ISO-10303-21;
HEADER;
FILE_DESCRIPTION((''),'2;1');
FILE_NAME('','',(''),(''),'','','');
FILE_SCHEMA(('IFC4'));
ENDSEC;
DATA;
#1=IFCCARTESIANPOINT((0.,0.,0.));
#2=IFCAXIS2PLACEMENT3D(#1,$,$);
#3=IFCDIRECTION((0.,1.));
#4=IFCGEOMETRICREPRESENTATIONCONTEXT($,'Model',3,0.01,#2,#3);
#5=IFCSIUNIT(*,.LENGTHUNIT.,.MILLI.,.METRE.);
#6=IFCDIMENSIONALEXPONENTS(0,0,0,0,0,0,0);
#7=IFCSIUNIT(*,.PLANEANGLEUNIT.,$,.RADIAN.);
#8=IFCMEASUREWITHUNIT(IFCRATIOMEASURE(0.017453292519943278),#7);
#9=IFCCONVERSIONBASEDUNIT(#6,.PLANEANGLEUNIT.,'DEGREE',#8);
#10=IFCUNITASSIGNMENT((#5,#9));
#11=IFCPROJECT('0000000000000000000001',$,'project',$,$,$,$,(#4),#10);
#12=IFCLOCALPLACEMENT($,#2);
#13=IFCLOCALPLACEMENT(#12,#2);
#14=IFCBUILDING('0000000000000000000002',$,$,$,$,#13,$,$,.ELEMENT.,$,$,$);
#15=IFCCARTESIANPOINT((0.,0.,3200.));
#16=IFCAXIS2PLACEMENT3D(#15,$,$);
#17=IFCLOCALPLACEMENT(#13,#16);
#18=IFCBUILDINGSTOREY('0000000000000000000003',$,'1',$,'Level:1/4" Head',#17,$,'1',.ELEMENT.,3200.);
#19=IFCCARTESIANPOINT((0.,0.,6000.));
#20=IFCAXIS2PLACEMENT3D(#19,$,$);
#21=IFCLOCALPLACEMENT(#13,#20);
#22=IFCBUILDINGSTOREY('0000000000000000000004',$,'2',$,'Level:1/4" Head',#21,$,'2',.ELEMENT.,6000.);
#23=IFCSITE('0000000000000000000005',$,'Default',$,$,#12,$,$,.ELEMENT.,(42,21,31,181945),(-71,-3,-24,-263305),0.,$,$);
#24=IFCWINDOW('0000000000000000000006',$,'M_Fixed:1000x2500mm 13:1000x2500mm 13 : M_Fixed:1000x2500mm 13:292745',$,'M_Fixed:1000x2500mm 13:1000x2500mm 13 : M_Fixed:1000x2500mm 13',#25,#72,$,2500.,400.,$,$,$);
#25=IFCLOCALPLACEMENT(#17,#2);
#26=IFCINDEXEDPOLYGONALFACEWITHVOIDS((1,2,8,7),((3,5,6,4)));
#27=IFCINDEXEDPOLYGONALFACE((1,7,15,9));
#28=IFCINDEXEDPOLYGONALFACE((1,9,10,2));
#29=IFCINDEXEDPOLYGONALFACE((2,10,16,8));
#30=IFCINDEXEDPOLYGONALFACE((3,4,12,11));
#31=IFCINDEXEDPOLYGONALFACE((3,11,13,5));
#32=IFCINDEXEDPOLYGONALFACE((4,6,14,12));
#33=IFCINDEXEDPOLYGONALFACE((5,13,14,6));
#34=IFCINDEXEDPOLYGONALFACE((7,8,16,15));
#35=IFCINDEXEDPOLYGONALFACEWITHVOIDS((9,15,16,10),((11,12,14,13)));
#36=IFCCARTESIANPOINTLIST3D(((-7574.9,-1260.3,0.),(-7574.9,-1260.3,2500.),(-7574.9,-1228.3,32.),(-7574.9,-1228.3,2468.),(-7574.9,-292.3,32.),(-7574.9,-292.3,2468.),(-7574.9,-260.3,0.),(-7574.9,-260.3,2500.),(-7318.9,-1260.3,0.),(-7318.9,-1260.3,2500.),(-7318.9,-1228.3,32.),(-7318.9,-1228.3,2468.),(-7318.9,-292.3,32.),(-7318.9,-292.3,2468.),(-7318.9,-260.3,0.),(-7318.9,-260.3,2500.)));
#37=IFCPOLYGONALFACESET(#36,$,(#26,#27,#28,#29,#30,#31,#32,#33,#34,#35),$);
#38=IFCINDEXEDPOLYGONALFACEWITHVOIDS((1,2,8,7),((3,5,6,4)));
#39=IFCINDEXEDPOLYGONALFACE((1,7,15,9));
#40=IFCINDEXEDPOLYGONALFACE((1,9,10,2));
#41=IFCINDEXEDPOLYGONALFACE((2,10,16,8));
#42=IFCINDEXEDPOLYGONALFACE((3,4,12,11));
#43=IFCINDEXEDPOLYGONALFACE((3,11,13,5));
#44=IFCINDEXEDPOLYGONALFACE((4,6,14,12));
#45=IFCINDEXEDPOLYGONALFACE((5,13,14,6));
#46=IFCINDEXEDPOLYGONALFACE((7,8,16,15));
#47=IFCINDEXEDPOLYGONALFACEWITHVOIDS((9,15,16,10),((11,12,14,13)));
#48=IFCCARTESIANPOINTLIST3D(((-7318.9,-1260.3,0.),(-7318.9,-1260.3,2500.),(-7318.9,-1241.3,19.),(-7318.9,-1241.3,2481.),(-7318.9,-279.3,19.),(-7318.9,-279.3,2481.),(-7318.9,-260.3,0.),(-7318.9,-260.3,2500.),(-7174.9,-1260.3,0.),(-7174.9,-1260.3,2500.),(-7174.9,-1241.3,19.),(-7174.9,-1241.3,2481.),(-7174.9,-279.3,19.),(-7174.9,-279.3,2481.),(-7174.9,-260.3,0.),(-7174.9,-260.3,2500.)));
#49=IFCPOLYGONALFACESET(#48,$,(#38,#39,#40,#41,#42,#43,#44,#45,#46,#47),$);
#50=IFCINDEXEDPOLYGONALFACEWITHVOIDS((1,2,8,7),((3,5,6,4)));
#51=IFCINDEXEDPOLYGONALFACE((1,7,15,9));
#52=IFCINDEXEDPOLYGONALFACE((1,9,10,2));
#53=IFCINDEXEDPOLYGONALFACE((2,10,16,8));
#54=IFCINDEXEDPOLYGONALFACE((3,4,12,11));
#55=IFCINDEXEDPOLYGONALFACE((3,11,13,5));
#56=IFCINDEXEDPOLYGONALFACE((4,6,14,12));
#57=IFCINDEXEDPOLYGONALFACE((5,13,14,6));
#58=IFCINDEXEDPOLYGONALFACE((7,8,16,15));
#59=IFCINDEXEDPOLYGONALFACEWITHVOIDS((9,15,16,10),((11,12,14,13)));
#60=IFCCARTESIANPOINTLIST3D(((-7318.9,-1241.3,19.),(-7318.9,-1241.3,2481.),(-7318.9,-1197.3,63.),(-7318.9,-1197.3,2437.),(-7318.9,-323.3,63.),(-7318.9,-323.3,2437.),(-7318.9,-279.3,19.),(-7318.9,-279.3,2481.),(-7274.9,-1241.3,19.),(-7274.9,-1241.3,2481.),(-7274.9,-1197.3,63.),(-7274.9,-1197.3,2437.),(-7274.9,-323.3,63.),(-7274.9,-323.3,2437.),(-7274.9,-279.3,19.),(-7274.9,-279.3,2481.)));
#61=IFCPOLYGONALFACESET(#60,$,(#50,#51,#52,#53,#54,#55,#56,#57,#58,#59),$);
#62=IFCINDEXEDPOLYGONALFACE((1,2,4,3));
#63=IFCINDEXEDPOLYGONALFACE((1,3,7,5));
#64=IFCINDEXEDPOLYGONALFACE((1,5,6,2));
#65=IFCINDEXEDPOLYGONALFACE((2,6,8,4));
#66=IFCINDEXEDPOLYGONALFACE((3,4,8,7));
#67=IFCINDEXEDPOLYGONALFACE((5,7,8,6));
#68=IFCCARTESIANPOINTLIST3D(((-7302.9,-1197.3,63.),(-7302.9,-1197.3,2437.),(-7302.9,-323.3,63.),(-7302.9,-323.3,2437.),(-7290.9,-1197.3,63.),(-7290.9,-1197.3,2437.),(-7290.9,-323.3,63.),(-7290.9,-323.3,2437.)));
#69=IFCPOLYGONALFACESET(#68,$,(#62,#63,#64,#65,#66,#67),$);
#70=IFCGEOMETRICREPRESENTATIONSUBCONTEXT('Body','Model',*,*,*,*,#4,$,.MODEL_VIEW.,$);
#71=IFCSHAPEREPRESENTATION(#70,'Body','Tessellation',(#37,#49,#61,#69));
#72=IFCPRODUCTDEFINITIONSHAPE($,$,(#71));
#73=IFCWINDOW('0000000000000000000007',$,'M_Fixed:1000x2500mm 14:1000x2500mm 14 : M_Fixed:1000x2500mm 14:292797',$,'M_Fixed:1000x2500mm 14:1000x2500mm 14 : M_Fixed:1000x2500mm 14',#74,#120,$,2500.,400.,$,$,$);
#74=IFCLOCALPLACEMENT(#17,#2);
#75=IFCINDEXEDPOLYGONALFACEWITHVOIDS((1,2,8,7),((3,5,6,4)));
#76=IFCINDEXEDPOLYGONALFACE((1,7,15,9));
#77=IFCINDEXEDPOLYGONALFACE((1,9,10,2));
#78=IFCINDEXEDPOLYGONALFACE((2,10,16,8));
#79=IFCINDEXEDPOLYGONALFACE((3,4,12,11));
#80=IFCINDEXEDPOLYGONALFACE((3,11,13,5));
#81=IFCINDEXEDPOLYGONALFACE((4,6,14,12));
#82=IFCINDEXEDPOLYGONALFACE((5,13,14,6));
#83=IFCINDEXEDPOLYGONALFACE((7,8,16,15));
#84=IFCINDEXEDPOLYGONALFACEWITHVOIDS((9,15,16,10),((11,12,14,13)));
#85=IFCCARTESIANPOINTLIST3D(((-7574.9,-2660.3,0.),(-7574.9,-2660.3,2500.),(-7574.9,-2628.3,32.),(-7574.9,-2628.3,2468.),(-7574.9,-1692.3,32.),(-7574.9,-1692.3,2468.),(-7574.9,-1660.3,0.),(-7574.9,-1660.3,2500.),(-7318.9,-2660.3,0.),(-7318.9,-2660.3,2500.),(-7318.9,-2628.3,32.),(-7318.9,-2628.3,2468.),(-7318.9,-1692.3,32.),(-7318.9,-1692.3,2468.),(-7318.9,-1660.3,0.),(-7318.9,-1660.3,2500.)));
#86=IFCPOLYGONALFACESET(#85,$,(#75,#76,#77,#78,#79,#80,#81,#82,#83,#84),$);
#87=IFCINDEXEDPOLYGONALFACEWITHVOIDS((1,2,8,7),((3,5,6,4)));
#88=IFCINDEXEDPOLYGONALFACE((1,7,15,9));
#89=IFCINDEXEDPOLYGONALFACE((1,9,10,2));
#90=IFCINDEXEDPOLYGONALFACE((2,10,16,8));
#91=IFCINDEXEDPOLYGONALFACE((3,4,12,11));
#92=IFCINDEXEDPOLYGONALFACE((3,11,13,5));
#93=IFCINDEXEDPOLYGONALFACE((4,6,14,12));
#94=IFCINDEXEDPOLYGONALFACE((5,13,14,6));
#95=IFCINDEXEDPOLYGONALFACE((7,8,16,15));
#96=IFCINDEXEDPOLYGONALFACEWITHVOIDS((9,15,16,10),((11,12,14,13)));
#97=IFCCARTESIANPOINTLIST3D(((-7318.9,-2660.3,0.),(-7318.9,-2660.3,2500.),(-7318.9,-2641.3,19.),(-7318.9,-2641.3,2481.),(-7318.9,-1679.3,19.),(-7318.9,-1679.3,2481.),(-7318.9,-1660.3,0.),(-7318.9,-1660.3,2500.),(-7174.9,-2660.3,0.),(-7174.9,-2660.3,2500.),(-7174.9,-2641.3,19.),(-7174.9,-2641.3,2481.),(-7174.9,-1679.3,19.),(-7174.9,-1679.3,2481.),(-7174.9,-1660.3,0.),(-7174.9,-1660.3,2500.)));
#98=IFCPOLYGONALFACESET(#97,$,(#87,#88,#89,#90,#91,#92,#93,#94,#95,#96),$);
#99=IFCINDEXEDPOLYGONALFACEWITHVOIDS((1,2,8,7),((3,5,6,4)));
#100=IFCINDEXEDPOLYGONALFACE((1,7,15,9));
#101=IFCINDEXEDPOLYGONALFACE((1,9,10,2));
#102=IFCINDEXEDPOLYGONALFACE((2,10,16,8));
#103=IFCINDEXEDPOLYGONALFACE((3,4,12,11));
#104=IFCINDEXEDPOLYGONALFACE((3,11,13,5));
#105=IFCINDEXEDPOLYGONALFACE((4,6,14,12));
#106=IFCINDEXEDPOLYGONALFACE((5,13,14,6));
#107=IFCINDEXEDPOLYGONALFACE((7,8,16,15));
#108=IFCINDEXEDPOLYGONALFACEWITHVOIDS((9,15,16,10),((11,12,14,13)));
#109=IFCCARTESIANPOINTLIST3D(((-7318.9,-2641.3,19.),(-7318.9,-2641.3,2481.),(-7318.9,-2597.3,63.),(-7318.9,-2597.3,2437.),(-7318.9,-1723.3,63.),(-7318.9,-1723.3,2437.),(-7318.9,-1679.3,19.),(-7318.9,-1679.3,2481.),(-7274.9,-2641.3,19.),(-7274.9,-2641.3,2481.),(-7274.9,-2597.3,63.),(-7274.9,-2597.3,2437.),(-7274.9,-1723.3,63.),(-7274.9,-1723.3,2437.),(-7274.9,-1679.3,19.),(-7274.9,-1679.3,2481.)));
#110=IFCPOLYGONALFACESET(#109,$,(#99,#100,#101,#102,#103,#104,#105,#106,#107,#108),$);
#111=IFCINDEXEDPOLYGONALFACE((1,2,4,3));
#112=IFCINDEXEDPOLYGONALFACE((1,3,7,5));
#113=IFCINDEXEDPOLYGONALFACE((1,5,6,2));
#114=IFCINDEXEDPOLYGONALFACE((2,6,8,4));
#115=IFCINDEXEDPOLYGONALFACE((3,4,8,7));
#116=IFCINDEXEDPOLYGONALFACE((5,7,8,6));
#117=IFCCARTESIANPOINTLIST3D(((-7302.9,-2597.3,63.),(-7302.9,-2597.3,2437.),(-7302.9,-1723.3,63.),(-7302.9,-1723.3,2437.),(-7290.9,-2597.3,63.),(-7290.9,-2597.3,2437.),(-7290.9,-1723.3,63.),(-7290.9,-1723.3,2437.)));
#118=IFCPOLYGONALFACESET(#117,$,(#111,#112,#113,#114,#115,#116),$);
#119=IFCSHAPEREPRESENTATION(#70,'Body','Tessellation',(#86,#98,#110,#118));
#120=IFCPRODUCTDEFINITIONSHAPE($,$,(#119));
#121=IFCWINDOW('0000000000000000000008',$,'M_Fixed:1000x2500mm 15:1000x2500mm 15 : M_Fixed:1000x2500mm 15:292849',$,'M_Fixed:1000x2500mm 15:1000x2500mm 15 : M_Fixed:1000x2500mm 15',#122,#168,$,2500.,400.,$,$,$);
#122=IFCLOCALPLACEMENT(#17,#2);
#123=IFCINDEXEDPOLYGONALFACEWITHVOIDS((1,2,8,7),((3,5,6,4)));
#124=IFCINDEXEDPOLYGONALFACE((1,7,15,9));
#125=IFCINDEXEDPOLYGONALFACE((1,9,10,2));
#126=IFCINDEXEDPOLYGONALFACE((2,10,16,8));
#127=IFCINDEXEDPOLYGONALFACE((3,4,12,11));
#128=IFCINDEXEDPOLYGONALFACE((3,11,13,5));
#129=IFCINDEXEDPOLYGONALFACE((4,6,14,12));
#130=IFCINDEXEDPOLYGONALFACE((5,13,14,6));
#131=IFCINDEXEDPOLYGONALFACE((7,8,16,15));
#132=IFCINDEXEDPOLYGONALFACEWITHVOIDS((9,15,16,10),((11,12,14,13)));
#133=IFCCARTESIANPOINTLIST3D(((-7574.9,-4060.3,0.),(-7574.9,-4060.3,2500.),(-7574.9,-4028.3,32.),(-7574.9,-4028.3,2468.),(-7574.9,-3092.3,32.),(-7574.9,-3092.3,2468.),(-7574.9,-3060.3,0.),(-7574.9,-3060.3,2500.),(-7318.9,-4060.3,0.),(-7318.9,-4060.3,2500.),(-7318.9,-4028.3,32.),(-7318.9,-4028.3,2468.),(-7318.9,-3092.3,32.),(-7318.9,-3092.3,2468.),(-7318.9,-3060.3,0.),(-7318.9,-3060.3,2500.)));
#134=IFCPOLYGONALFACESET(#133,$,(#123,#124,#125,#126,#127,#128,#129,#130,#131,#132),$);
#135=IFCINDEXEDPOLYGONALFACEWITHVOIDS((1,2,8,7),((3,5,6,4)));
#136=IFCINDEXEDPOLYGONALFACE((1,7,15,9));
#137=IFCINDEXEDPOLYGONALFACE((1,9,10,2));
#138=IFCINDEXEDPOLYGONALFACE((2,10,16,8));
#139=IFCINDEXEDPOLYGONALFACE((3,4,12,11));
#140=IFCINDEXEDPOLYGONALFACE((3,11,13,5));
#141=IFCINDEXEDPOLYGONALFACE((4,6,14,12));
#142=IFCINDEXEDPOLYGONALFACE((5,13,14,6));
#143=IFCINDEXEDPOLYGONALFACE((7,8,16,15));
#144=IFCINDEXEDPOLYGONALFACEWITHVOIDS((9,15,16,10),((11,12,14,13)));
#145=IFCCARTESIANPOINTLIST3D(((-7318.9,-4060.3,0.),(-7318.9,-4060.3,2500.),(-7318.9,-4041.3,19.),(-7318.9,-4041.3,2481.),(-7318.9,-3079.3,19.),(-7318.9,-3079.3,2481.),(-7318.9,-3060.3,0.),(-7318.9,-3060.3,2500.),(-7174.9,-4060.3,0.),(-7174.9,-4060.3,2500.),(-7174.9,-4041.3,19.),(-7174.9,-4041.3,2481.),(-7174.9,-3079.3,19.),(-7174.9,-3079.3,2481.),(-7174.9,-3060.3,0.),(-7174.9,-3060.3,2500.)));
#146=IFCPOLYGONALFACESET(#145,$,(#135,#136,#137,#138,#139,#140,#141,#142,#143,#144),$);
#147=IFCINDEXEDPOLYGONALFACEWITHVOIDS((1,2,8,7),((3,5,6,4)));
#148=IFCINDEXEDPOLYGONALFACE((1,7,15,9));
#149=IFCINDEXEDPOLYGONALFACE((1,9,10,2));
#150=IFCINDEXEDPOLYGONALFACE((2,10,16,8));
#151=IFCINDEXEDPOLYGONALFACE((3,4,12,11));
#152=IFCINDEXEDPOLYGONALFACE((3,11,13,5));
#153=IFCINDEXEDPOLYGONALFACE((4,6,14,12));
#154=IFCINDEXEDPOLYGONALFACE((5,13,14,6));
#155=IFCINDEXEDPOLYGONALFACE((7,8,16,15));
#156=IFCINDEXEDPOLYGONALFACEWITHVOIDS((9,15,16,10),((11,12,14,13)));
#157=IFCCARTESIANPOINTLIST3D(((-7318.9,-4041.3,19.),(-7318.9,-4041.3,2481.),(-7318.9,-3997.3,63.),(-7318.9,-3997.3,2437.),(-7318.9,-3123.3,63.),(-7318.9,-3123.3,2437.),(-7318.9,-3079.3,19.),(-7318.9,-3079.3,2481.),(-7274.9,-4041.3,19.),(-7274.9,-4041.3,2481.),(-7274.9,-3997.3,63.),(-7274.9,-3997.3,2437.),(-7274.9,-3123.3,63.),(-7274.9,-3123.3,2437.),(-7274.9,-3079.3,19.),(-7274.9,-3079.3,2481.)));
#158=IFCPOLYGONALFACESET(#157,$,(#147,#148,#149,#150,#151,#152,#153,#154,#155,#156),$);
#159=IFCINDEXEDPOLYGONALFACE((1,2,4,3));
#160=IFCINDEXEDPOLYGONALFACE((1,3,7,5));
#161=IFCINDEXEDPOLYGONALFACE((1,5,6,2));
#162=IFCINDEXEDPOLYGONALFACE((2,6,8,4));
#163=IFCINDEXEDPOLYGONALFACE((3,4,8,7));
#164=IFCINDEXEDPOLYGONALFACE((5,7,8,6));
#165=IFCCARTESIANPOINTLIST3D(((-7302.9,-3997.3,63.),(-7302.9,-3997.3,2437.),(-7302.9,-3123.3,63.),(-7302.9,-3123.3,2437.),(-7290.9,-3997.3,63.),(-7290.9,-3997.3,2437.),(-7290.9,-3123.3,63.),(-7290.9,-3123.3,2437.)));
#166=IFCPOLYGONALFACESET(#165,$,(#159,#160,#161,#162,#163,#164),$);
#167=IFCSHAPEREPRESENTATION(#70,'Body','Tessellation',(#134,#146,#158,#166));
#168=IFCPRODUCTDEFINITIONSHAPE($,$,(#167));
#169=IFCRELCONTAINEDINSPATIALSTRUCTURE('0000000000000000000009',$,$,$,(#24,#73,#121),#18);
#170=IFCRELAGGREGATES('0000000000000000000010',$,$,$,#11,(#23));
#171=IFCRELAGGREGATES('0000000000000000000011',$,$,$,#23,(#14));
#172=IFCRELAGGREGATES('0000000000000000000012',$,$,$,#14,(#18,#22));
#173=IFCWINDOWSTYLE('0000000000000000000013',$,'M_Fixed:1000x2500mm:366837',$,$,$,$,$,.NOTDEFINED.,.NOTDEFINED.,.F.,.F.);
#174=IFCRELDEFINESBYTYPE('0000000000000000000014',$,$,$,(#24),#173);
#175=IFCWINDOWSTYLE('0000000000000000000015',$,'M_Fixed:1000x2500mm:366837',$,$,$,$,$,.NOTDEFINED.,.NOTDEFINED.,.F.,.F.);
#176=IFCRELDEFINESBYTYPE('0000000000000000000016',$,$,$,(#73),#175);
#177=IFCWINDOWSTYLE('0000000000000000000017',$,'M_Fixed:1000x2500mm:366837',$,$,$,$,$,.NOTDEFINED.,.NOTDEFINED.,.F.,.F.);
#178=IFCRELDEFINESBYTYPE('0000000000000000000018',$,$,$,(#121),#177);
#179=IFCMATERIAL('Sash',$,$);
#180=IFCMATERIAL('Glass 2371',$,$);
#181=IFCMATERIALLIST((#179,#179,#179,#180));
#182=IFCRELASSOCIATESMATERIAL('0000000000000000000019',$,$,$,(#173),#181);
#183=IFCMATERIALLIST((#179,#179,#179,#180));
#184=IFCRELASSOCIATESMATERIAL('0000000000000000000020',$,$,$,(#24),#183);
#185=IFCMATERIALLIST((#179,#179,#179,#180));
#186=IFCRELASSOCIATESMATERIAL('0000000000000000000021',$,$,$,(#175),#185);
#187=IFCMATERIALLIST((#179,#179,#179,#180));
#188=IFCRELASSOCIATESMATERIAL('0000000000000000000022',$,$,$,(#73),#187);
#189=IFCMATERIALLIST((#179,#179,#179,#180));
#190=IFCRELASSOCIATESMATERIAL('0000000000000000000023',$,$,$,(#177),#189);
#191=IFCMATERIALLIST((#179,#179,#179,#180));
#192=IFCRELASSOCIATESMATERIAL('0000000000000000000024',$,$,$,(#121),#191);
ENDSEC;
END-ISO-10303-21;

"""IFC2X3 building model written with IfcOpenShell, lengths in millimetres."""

from ifc_helpers import new_model, entity, si_unit, converted_unit, direction, frame, frame_2d, origin, place, context, subcontext, project, spatial, polyline, rectangle, outline, extrude, source, transform, mapped, material, material_list, type_object, type_shapes, element, save


model = new_model("IFC2X3")

# Units and contexts
model_context = context("Model", 3, precision=0.01, world=origin(), true_north=direction((0.0, 1.0)))
body_context = subcontext(model_context, "Body", "Model", "MODEL_VIEW")
ifc_project = project(units=[si_unit("LENGTHUNIT", "METRE", prefix="MILLI"), converted_unit("PLANEANGLEUNIT", "DEGREE", entity("IfcRatioMeasure", 0.017453292519943278), si_unit("PLANEANGLEUNIT", "RADIAN"), dimensions=[0, 0, 0, 0, 0, 0, 0])], contexts=[model_context])

# Site, building, storey
site_placement = place(None, origin())
site = spatial("IfcSite", under=ifc_project, at=site_placement, Name="Default", CompositionType="ELEMENT", RefLatitude=(42, 21, 31, 181945), RefLongitude=(-71, -3, -24, -263305), RefElevation=0.0)
building_placement = place(site_placement, origin())
building = spatial("IfcBuilding", under=site, at=building_placement, CompositionType="ELEMENT")
storey_1_placement = place(building_placement, frame((0.0, 0.0, 3200.0)))
storey_1 = spatial("IfcBuildingStorey", under=building, at=storey_1_placement, Name="1", ObjectType="Level:1/4\" Head", LongName="1", CompositionType="ELEMENT", Elevation=3200.0)

# Shared definitions
storey_2_placement = place(building_placement, frame((0.0, 0.0, 6000.0)))
storey_2 = spatial("IfcBuildingStorey", under=building, at=storey_2_placement, Name="2", ObjectType="Level:1/4\" Head", LongName="2", CompositionType="ELEMENT", Elevation=6000.0)

# Shared definitions
ifc_material_1 = material(Name="Sash")
ifc_material_2 = material(Name="Glass 2371")

# Windows
ifc_material_list_1 = material_list([ifc_material_1, ifc_material_1, ifc_material_1, ifc_material_2])
ifc_material_list_2 = material_list([ifc_material_1, ifc_material_1, ifc_material_1, ifc_material_2])
window_style_1 = type_object("IfcWindowStyle", Name="M_Fixed:1000x2500mm:366837", ConstructionType="NOTDEFINED", OperationType="NOTDEFINED", ParameterTakesPrecedence=False, Sizeable=False, material=ifc_material_list_2)
shared_shape_1 = source(origin(), body_context, "Body", "SweptSolid", [
    extrude(outline(polyline([(-1250.0, -500.0), (1250.0, -500.0), (1250.0, 500.0), (-1250.0, 500.0), (-1250.0, -500.0)]), holes=[polyline([(1218.0, 468.0), (1218.0, -468.0), (-1218.0, -468.0), (-1218.0, 468.0), (1218.0, 468.0)])]), frame((-7574.9, -760.3, 4450.0), z_axis=(1.0, 0.0, 0.0), x_axis=(0.0, 0.0, -1.0)), (0.0, 0.0, 1.0), 256.0),
    extrude(outline(polyline([(-1250.0, -500.0), (1250.0, -500.0), (1250.0, 500.0), (-1250.0, 500.0), (-1250.0, -500.0)]), holes=[polyline([(1231.0, 481.0), (1231.0, -481.0), (-1231.0, -481.0), (-1231.0, 481.0), (1231.0, 481.0)])]), frame((-7318.9, -760.3, 4450.0), z_axis=(1.0, 0.0, 0.0), x_axis=(0.0, 0.0, -1.0)), (0.0, 0.0, 1.0), 144.0),
    extrude(outline(polyline([(-1231.0, -481.0), (1231.0, -481.0), (1231.0, 481.0), (-1231.0, 481.0), (-1231.0, -481.0)]), holes=[polyline([(1187.0, 437.0), (1187.0, -437.0), (-1187.0, -437.0), (-1187.0, 437.0), (1187.0, 437.0)])]), frame((-7318.9, -760.3, 4450.0), z_axis=(1.0, 0.0, 0.0), x_axis=(0.0, 0.0, -1.0)), (0.0, 0.0, 1.0), 44.0),
    extrude(rectangle(XDim=874.0, YDim=12.0, at=frame_2d((0.0, 0.0), x_axis=(1.0, 0.0))), frame((-7296.9, -760.3, 3263.0), z_axis=(0.0, 0.0, 1.0), x_axis=(0.0, -1.0, 0.0)), (0.0, 0.0, 1.0), 2374.0),
])
type_shapes(window_style_1, [shared_shape_1])
window_1_placement = place(storey_1_placement, frame((0.0, 0.0, -3200.0)))
element("IfcWindow", 1, at=window_1_placement, inside=storey_1, type_object=window_style_1, material=ifc_material_list_1, Name="M_Fixed:1000x2500mm 13:1000x2500mm 13 : M_Fixed:1000x2500mm 13:292745", ObjectType="M_Fixed:1000x2500mm 13:1000x2500mm 13 : M_Fixed:1000x2500mm 13", OverallHeight=2500.0, OverallWidth=400.0, context=body_context, shape_type="MappedRepresentation", body=[
    mapped(shared_shape_1, transform((0.0, 0.0, 0.0), scale=1.0)),
])
ifc_material_list_3 = material_list([ifc_material_1, ifc_material_1, ifc_material_1, ifc_material_2])
ifc_material_list_4 = material_list([ifc_material_1, ifc_material_1, ifc_material_1, ifc_material_2])
window_style_2 = type_object("IfcWindowStyle", Name="M_Fixed:1000x2500mm:366837", ConstructionType="NOTDEFINED", OperationType="NOTDEFINED", ParameterTakesPrecedence=False, Sizeable=False, material=ifc_material_list_4)
shared_shape_2 = source(origin(), body_context, "Body", "SweptSolid", [
    extrude(outline(polyline([(-1250.0, -500.0), (1250.0, -500.0), (1250.0, 500.0), (-1250.0, 500.0), (-1250.0, -500.0)]), holes=[polyline([(1218.0, 468.0), (1218.0, -468.0), (-1218.0, -468.0), (-1218.0, 468.0), (1218.0, 468.0)])]), frame((-7574.9, -2160.3, 4450.0), z_axis=(1.0, 0.0, 0.0), x_axis=(0.0, 0.0, -1.0)), (0.0, 0.0, 1.0), 256.0),
    extrude(outline(polyline([(-1250.0, -500.0), (1250.0, -500.0), (1250.0, 500.0), (-1250.0, 500.0), (-1250.0, -500.0)]), holes=[polyline([(1231.0, 481.0), (1231.0, -481.0), (-1231.0, -481.0), (-1231.0, 481.0), (1231.0, 481.0)])]), frame((-7318.9, -2160.3, 4450.0), z_axis=(1.0, 0.0, 0.0), x_axis=(0.0, 0.0, -1.0)), (0.0, 0.0, 1.0), 144.0),
    extrude(outline(polyline([(-1231.0, -481.0), (1231.0, -481.0), (1231.0, 481.0), (-1231.0, 481.0), (-1231.0, -481.0)]), holes=[polyline([(1187.0, 437.0), (1187.0, -437.0), (-1187.0, -437.0), (-1187.0, 437.0), (1187.0, 437.0)])]), frame((-7318.9, -2160.3, 4450.0), z_axis=(1.0, 0.0, 0.0), x_axis=(0.0, 0.0, -1.0)), (0.0, 0.0, 1.0), 44.0),
    extrude(rectangle(XDim=874.0, YDim=12.0, at=frame_2d((0.0, 0.0), x_axis=(1.0, 0.0))), frame((-7296.9, -2160.3, 3263.0), z_axis=(0.0, 0.0, 1.0), x_axis=(0.0, -1.0, 0.0)), (0.0, 0.0, 1.0), 2374.0),
])
type_shapes(window_style_2, [shared_shape_2])
window_2_placement = place(storey_1_placement, frame((0.0, 0.0, -3200.0)))
element("IfcWindow", 2, at=window_2_placement, inside=storey_1, type_object=window_style_2, material=ifc_material_list_3, Name="M_Fixed:1000x2500mm 14:1000x2500mm 14 : M_Fixed:1000x2500mm 14:292797", ObjectType="M_Fixed:1000x2500mm 14:1000x2500mm 14 : M_Fixed:1000x2500mm 14", OverallHeight=2500.0, OverallWidth=400.0, context=body_context, shape_type="MappedRepresentation", body=[
    mapped(shared_shape_2, transform((0.0, 0.0, 0.0), scale=1.0)),
])
ifc_material_list_5 = material_list([ifc_material_1, ifc_material_1, ifc_material_1, ifc_material_2])
ifc_material_list_6 = material_list([ifc_material_1, ifc_material_1, ifc_material_1, ifc_material_2])
window_style_3 = type_object("IfcWindowStyle", Name="M_Fixed:1000x2500mm:366837", ConstructionType="NOTDEFINED", OperationType="NOTDEFINED", ParameterTakesPrecedence=False, Sizeable=False, material=ifc_material_list_6)
shared_shape_3 = source(origin(), body_context, "Body", "SweptSolid", [
    extrude(outline(polyline([(-1250.0, -500.0), (1250.0, -500.0), (1250.0, 500.0), (-1250.0, 500.0), (-1250.0, -500.0)]), holes=[polyline([(1218.0, 468.0), (1218.0, -468.0), (-1218.0, -468.0), (-1218.0, 468.0), (1218.0, 468.0)])]), frame((-7574.9, -3560.3, 4450.0), z_axis=(1.0, 0.0, 0.0), x_axis=(0.0, 0.0, -1.0)), (0.0, 0.0, 1.0), 256.0),
    extrude(outline(polyline([(-1250.0, -500.0), (1250.0, -500.0), (1250.0, 500.0), (-1250.0, 500.0), (-1250.0, -500.0)]), holes=[polyline([(1231.0, 481.0), (1231.0, -481.0), (-1231.0, -481.0), (-1231.0, 481.0), (1231.0, 481.0)])]), frame((-7318.9, -3560.3, 4450.0), z_axis=(1.0, 0.0, 0.0), x_axis=(0.0, 0.0, -1.0)), (0.0, 0.0, 1.0), 144.0),
    extrude(outline(polyline([(-1231.0, -481.0), (1231.0, -481.0), (1231.0, 481.0), (-1231.0, 481.0), (-1231.0, -481.0)]), holes=[polyline([(1187.0, 437.0), (1187.0, -437.0), (-1187.0, -437.0), (-1187.0, 437.0), (1187.0, 437.0)])]), frame((-7318.9, -3560.3, 4450.0), z_axis=(1.0, 0.0, 0.0), x_axis=(0.0, 0.0, -1.0)), (0.0, 0.0, 1.0), 44.0),
    extrude(rectangle(XDim=874.0, YDim=12.0, at=frame_2d((0.0, 0.0), x_axis=(1.0, 0.0))), frame((-7296.9, -3560.3, 3263.0), z_axis=(0.0, 0.0, 1.0), x_axis=(0.0, -1.0, 0.0)), (0.0, 0.0, 1.0), 2374.0),
])
type_shapes(window_style_3, [shared_shape_3])
window_3_placement = place(storey_1_placement, frame((0.0, 0.0, -3200.0)))
element("IfcWindow", 3, at=window_3_placement, inside=storey_1, type_object=window_style_3, material=ifc_material_list_5, Name="M_Fixed:1000x2500mm 15:1000x2500mm 15 : M_Fixed:1000x2500mm 15:292849", ObjectType="M_Fixed:1000x2500mm 15:1000x2500mm 15 : M_Fixed:1000x2500mm 15", OverallHeight=2500.0, OverallWidth=400.0, context=body_context, shape_type="MappedRepresentation", body=[
    mapped(shared_shape_3, transform((0.0, 0.0, 0.0), scale=1.0)),
])

save(model, "model.ifc")
